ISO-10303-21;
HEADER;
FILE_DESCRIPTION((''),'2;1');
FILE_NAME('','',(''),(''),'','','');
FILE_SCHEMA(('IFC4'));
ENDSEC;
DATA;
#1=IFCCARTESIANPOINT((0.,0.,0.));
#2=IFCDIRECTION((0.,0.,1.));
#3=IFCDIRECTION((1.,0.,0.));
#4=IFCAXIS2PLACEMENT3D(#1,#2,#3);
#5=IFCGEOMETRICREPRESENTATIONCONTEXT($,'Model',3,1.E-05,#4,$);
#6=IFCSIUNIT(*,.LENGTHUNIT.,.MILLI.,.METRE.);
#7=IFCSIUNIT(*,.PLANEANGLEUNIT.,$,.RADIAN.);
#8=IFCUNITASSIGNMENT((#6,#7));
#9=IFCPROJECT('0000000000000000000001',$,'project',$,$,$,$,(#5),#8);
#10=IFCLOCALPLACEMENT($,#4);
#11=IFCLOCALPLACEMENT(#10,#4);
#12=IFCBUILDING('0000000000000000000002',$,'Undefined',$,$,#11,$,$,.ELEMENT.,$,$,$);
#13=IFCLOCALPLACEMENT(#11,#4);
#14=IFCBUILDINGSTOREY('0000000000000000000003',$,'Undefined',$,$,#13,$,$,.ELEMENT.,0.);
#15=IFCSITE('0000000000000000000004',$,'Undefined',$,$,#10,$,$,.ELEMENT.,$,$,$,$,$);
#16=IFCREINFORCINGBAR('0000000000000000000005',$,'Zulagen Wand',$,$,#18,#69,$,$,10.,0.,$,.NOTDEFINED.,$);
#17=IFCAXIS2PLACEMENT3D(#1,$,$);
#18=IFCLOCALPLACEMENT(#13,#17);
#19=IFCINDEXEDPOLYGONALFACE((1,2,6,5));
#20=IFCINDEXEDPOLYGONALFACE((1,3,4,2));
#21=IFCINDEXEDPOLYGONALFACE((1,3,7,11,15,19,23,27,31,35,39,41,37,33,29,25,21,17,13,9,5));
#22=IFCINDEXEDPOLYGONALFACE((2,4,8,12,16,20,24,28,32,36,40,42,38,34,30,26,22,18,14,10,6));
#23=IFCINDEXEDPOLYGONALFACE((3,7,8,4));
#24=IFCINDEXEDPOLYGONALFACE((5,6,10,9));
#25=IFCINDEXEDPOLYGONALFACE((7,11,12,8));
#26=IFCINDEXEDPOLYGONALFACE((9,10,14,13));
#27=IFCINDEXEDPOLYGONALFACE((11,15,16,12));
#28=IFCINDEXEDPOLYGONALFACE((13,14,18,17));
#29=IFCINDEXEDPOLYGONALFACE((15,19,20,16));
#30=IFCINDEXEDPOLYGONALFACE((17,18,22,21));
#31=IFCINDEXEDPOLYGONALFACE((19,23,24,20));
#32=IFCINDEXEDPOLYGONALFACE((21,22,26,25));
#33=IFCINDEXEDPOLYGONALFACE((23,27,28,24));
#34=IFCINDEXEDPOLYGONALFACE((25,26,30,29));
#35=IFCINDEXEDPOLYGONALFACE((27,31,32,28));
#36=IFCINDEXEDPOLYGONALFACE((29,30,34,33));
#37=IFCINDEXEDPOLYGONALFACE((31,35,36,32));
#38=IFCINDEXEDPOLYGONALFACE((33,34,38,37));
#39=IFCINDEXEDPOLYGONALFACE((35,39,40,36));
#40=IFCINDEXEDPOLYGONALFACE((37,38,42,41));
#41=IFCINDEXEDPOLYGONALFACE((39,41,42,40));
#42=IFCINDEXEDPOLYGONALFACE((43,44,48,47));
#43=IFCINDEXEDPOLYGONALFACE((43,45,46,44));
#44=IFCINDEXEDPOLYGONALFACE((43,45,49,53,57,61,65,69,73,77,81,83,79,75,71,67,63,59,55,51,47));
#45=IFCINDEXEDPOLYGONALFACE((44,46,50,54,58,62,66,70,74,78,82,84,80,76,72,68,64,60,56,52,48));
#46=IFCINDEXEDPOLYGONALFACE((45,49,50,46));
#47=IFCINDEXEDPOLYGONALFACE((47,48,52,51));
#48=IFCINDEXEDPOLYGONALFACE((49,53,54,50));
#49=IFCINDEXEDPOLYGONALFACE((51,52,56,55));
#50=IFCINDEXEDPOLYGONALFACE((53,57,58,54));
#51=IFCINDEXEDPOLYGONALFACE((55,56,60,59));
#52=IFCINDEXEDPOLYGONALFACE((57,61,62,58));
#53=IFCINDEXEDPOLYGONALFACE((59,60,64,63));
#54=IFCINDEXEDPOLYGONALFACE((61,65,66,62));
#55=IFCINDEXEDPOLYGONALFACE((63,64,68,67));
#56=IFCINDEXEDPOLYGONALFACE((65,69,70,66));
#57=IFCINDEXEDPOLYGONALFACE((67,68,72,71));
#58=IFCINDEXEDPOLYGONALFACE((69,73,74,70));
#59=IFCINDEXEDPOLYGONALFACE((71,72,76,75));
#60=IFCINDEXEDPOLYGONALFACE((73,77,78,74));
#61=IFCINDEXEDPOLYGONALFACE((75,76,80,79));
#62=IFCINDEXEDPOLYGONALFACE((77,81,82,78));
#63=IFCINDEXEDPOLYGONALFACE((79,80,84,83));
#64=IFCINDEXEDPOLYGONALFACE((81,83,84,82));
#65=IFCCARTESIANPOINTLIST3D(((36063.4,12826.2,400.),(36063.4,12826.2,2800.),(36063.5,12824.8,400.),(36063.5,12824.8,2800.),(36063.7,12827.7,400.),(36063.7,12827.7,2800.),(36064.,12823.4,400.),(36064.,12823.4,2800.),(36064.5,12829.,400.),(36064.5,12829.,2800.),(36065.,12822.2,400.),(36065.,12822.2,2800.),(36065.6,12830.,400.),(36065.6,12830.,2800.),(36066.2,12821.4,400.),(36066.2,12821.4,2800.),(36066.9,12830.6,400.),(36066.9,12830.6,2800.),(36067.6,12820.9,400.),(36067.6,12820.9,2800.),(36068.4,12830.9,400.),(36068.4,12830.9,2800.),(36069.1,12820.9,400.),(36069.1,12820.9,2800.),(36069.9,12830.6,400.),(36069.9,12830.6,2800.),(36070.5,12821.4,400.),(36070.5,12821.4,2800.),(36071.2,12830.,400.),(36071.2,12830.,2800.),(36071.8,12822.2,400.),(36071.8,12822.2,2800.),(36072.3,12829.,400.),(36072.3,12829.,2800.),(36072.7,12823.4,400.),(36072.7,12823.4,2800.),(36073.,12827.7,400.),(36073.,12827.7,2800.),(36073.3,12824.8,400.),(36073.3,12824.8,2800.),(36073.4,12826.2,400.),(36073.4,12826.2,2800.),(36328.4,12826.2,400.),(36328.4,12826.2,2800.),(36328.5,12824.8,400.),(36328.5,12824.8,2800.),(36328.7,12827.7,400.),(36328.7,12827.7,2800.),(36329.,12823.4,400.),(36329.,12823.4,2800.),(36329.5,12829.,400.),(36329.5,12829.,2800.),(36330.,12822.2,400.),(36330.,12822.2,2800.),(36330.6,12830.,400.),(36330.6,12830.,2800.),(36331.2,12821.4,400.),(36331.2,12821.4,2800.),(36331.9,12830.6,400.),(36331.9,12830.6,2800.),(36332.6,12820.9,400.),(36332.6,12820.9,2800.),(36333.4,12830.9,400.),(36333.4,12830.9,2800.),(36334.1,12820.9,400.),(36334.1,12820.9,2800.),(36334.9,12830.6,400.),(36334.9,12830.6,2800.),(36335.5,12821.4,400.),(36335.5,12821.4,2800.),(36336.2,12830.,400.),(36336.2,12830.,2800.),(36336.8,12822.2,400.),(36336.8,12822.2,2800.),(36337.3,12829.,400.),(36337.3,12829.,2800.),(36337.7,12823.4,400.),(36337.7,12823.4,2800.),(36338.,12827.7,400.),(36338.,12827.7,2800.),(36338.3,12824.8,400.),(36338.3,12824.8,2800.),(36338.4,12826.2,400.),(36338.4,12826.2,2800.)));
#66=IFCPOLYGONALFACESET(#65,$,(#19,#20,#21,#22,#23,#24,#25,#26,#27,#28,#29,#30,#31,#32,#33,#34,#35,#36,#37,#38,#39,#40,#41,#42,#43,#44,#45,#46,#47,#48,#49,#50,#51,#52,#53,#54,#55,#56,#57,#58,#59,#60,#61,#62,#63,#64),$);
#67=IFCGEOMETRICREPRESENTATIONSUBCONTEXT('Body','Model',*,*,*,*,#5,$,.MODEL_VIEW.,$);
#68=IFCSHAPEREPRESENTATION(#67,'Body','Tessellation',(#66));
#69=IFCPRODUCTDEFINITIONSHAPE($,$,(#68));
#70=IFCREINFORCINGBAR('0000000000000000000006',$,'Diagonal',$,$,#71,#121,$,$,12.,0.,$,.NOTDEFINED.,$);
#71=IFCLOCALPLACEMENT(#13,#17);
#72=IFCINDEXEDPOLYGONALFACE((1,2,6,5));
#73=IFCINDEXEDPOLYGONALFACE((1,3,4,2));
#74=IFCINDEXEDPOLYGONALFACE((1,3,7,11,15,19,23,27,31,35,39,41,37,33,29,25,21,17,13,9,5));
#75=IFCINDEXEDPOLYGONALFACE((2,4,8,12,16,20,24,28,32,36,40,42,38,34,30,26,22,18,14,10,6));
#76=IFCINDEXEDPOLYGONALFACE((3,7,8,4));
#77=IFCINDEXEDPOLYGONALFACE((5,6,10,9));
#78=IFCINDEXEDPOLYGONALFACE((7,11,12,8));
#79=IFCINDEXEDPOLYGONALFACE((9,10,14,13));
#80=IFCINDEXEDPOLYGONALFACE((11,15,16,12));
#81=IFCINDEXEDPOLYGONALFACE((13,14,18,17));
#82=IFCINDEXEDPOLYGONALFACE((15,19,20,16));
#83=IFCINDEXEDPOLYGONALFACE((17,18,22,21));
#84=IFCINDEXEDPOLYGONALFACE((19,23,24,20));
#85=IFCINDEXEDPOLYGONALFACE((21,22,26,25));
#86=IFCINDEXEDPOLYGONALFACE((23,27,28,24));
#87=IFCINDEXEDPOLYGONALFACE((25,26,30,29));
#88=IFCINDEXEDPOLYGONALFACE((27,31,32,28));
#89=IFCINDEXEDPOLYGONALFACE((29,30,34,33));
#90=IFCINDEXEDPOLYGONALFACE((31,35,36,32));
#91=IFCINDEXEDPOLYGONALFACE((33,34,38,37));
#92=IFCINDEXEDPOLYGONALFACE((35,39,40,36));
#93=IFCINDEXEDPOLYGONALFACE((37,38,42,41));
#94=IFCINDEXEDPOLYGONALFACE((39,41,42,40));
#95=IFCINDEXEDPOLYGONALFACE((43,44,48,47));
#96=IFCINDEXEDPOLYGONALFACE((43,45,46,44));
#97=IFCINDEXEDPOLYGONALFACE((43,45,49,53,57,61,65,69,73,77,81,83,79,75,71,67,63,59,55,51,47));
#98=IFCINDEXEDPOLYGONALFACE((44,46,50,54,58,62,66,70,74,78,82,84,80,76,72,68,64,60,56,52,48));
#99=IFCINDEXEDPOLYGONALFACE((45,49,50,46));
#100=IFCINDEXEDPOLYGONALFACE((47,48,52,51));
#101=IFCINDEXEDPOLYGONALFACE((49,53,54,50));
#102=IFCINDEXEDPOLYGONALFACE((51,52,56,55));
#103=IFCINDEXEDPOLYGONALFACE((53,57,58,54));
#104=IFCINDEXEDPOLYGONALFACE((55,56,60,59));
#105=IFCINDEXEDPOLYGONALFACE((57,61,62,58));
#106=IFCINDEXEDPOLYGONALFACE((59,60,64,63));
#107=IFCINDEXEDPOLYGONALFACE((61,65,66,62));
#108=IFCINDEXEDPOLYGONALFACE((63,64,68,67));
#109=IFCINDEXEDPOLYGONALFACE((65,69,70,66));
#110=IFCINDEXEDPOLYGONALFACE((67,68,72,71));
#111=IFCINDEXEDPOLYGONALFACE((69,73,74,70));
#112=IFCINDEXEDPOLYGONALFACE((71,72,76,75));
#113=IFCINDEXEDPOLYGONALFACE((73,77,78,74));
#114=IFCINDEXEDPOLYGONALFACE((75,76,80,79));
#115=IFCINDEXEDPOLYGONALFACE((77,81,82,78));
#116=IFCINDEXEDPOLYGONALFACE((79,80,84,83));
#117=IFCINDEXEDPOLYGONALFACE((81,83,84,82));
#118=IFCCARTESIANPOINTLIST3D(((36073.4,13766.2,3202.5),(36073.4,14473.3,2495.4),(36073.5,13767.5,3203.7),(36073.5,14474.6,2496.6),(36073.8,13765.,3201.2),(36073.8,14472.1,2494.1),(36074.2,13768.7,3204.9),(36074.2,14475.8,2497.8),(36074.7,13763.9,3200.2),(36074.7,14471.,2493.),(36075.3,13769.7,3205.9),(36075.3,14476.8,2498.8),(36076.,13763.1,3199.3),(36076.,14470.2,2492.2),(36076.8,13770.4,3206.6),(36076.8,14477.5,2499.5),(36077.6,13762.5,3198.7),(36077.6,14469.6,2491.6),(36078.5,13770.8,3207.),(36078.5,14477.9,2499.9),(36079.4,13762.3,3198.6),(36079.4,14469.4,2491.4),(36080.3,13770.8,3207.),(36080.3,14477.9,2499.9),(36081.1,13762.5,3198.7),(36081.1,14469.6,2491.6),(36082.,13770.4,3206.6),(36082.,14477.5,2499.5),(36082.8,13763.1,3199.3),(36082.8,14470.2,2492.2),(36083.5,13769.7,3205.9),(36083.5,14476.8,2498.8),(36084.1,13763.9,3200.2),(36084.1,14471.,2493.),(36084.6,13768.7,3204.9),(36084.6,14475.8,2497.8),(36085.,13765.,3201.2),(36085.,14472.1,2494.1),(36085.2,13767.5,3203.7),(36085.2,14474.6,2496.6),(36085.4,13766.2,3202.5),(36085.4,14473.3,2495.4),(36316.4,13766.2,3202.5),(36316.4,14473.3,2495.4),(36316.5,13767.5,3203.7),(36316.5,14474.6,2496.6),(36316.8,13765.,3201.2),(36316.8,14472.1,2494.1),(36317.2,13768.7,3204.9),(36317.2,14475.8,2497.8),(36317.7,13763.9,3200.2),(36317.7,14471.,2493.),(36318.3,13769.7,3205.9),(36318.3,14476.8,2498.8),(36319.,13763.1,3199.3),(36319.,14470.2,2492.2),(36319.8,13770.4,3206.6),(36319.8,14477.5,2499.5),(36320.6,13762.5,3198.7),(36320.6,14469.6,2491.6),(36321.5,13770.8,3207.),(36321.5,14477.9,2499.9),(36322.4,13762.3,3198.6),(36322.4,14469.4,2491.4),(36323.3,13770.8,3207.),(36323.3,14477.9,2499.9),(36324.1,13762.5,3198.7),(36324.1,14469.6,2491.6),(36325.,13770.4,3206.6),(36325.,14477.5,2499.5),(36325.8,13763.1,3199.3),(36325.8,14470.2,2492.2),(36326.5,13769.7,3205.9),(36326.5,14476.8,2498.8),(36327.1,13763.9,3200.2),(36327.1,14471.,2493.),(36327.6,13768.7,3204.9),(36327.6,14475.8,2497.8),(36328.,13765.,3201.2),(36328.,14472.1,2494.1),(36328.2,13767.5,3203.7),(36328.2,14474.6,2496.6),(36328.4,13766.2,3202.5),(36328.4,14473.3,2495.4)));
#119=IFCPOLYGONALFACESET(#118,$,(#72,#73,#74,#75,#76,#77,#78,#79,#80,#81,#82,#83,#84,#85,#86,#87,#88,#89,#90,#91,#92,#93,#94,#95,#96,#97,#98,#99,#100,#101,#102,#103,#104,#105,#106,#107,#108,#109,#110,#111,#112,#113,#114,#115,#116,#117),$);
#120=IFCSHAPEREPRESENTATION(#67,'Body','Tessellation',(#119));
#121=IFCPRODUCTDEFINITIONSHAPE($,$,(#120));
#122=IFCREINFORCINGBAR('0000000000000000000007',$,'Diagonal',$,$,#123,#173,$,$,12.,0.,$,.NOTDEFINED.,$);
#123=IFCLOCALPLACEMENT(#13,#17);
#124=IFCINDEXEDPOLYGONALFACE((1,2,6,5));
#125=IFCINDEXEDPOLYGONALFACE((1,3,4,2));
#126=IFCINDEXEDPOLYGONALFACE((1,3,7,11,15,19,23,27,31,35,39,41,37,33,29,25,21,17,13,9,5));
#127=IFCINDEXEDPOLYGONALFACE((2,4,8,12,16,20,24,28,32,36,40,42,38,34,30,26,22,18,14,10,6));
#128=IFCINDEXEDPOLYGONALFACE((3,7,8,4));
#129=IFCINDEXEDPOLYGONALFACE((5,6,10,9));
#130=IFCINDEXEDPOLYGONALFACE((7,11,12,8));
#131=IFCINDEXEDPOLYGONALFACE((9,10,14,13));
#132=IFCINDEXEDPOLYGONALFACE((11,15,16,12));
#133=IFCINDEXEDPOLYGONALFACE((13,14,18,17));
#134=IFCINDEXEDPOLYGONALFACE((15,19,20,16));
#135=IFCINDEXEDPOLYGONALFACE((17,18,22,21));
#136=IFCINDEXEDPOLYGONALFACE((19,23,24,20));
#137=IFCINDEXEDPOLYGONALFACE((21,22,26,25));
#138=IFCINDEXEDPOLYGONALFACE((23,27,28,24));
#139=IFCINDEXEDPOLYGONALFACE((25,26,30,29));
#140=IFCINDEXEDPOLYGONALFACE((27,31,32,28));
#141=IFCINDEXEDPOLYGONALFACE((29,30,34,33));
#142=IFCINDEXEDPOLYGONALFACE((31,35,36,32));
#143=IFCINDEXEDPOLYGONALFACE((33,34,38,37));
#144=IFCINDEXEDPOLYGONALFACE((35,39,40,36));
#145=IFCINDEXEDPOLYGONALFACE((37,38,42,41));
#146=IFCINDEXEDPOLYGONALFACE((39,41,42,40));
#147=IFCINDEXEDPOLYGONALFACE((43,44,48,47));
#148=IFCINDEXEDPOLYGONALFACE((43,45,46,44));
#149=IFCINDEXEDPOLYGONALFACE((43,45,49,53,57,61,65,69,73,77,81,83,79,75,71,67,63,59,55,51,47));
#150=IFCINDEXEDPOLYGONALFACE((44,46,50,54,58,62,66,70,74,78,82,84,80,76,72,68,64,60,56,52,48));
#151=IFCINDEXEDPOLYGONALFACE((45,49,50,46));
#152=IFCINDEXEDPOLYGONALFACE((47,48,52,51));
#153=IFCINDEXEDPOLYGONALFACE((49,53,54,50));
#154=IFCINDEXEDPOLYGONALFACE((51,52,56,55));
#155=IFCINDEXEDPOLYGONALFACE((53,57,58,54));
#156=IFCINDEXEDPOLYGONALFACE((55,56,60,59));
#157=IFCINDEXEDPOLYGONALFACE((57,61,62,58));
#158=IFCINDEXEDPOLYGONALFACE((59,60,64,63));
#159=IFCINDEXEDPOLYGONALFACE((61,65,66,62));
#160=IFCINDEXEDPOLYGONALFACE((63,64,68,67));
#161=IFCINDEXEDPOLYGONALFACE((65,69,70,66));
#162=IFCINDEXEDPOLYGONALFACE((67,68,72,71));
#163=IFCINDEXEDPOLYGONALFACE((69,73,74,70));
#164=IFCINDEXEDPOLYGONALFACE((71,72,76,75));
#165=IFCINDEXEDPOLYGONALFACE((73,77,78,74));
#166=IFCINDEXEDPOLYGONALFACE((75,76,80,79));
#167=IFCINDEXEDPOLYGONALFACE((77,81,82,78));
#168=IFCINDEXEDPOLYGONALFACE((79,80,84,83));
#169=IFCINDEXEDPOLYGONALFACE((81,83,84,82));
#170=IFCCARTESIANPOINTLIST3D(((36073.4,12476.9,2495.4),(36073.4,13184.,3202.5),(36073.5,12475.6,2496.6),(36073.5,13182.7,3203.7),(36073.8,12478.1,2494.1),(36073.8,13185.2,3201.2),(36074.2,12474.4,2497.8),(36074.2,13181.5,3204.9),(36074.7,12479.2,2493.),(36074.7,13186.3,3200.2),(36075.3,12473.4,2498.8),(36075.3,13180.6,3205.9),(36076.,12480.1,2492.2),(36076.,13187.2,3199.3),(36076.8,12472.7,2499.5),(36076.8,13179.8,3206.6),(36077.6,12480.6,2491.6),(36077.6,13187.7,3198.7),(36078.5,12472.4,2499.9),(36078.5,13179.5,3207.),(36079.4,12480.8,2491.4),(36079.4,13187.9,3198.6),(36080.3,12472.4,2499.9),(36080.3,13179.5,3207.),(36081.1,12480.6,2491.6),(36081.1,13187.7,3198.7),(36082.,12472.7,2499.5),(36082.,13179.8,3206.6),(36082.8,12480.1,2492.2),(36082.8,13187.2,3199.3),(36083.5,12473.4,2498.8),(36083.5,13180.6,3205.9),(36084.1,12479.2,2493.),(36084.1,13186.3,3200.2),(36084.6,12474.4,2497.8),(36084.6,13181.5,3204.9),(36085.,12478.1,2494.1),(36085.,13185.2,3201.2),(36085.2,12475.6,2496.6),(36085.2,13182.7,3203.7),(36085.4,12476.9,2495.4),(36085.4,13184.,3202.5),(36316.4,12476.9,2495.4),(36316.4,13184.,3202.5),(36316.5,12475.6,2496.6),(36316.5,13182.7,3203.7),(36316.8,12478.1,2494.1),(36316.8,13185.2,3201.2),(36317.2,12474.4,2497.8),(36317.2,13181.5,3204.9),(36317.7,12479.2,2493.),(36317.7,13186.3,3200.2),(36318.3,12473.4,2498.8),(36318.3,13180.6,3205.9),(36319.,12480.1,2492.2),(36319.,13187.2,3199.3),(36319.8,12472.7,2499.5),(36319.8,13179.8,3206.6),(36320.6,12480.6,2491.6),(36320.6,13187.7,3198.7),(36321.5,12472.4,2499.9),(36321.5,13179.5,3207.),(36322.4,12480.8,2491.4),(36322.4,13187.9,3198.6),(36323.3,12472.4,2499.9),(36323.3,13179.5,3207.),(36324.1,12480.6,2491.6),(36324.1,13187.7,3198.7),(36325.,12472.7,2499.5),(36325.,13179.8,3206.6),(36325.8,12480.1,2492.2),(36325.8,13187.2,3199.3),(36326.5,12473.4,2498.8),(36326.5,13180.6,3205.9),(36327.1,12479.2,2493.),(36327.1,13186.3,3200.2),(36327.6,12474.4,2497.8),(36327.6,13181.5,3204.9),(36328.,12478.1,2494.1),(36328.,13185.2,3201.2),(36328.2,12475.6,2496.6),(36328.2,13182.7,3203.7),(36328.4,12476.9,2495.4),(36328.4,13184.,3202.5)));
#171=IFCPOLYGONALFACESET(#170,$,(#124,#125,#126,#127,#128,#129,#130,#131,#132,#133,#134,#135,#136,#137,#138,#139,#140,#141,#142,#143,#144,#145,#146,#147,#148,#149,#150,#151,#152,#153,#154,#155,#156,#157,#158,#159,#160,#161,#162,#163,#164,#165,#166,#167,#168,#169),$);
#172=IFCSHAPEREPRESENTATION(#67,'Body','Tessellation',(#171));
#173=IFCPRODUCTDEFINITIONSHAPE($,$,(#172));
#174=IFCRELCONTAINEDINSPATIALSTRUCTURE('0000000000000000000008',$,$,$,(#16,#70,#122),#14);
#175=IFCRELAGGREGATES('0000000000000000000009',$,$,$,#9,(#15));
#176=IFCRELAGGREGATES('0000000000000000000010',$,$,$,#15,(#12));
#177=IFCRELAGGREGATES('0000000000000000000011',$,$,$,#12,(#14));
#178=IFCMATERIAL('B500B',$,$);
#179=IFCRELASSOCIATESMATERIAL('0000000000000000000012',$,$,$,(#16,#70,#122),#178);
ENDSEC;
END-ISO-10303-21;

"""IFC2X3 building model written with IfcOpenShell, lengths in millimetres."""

from ifc_helpers import new_model, entity, si_unit, frame, origin_with_axes, place, context, subcontext, project, spatial, source, transform, mapped, material, element, save


model = new_model("IFC2X3")

# Units and contexts
model_context = context("Model", 3, precision=1e-05, world=origin_with_axes())
body_context = subcontext(model_context, "Body", "Model", "MODEL_VIEW")
ifc_project = project(units=[si_unit("LENGTHUNIT", "METRE", prefix="MILLI"), si_unit("PLANEANGLEUNIT", "RADIAN")], contexts=[model_context])

# Site, building, storey
site_placement = place(None, origin_with_axes())
site = spatial("IfcSite", under=ifc_project, at=site_placement, Name="Undefined", CompositionType="ELEMENT")
building_placement = place(site_placement, origin_with_axes())
building = spatial("IfcBuilding", under=site, at=building_placement, Name="Undefined", CompositionType="ELEMENT")
storey_placement = place(building_placement, origin_with_axes())
storey = spatial("IfcBuildingStorey", under=building, at=storey_placement, Name="Undefined", CompositionType="ELEMENT", Elevation=0.0)

# Reinforcing bars
ifc_material_1 = material(Name="B500B")
shared_shape_1 = source(origin_with_axes(), body_context, "Body", "AdvancedSweptSolid", [
    entity("IfcSweptDiskSolid", entity("IfcTrimmedCurve", entity("IfcLine", entity("IfcCartesianPoint", [0.0, 0.0, 0.0]), entity("IfcVector", entity("IfcDirection", [1.0, 0.0, 0.0]), 1.0)), [entity("IfcParameterValue", 0.0)], [entity("IfcParameterValue", 2400.0)], True, "PARAMETER"), 5.0, None, 0.0, 2400.0),
])
shared_shape_2 = source(origin_with_axes(), body_context, "Body", "AdvancedSweptSolid", [
    entity("IfcSweptDiskSolid", entity("IfcTrimmedCurve", entity("IfcLine", entity("IfcCartesianPoint", [0.0, 0.0, 0.0]), entity("IfcVector", entity("IfcDirection", [1.0, 0.0, 0.0]), 1.0)), [entity("IfcParameterValue", 0.0)], [entity("IfcParameterValue", 2400.0)], True, "PARAMETER"), 5.0, None, 0.0, 2400.0),
])
reinforcing_bar_1_placement = place(storey_placement, frame((36068.4, 12825.9, 400.0), z_axis=(0.0, 1.0, 0.0), x_axis=(0.0, 0.0, 1.0)))
element("IfcReinforcingBar", 1, at=reinforcing_bar_1_placement, inside=storey, material=ifc_material_1, Name="Zulagen Wand", BarRole="NOTDEFINED", CrossSectionArea=0.0, NominalDiameter=10.0, context=body_context, shape_type="MappedRepresentation", body=[
    mapped(shared_shape_1, transform((0.0, 0.0, 0.0))),
    mapped(shared_shape_2, transform((0.0, 265.0, 0.0))),
])
shared_shape_3 = source(origin_with_axes(), body_context, "Body", "AdvancedSweptSolid", [
    entity("IfcSweptDiskSolid", entity("IfcTrimmedCurve", entity("IfcLine", entity("IfcCartesianPoint", [0.0, 0.0, 0.0]), entity("IfcVector", entity("IfcDirection", [1.0, 0.0, 0.0]), 1.0)), [entity("IfcParameterValue", 0.0)], [entity("IfcParameterValue", 1000.0)], True, "PARAMETER"), 6.0, None, 0.0, 1000.0),
])
shared_shape_4 = source(origin_with_axes(), body_context, "Body", "AdvancedSweptSolid", [
    entity("IfcSweptDiskSolid", entity("IfcTrimmedCurve", entity("IfcLine", entity("IfcCartesianPoint", [0.0, 0.0, 0.0]), entity("IfcVector", entity("IfcDirection", [1.0, 0.0, 0.0]), 1.0)), [entity("IfcParameterValue", 0.0)], [entity("IfcParameterValue", 1000.0)], True, "PARAMETER"), 6.0, None, 0.0, 1000.0),
])
reinforcing_bar_2_placement = place(storey_placement, frame((36079.4, 13766.6, 3202.8), z_axis=(0.0, -0.707107, -0.707107), x_axis=(0.0, 0.707107, -0.707107)))
element("IfcReinforcingBar", 2, at=reinforcing_bar_2_placement, inside=storey, material=ifc_material_1, Name="Diagonal", BarRole="NOTDEFINED", CrossSectionArea=0.0, NominalDiameter=12.0, context=body_context, shape_type="MappedRepresentation", body=[
    mapped(shared_shape_3, transform((0.0, 0.0, 0.0))),
    mapped(shared_shape_4, transform((0.0, 243.0, 0.0))),
])
shared_shape_5 = source(origin_with_axes(), body_context, "Body", "AdvancedSweptSolid", [
    entity("IfcSweptDiskSolid", entity("IfcTrimmedCurve", entity("IfcLine", entity("IfcCartesianPoint", [0.0, 0.0, 0.0]), entity("IfcVector", entity("IfcDirection", [1.0, 0.0, 0.0]), 1.0)), [entity("IfcParameterValue", 0.0)], [entity("IfcParameterValue", 1000.0)], True, "PARAMETER"), 6.0, None, 0.0, 1000.0),
])
shared_shape_6 = source(origin_with_axes(), body_context, "Body", "AdvancedSweptSolid", [
    entity("IfcSweptDiskSolid", entity("IfcTrimmedCurve", entity("IfcLine", entity("IfcCartesianPoint", [0.0, 0.0, 0.0]), entity("IfcVector", entity("IfcDirection", [1.0, 0.0, 0.0]), 1.0)), [entity("IfcParameterValue", 0.0)], [entity("IfcParameterValue", 1000.0)], True, "PARAMETER"), 6.0, None, 0.0, 1000.0),
])
reinforcing_bar_3_placement = place(storey_placement, frame((36079.4, 12476.6, 2495.7), z_axis=(0.0, 0.707107, -0.707107), x_axis=(0.0, 0.707107, 0.707107)))
element("IfcReinforcingBar", 3, at=reinforcing_bar_3_placement, inside=storey, material=ifc_material_1, Name="Diagonal", BarRole="NOTDEFINED", CrossSectionArea=0.0, NominalDiameter=12.0, context=body_context, shape_type="MappedRepresentation", body=[
    mapped(shared_shape_5, transform((0.0, 0.0, 0.0))),
    mapped(shared_shape_6, transform((0.0, 243.0, 0.0))),
])

save(model, "model.ifc")
